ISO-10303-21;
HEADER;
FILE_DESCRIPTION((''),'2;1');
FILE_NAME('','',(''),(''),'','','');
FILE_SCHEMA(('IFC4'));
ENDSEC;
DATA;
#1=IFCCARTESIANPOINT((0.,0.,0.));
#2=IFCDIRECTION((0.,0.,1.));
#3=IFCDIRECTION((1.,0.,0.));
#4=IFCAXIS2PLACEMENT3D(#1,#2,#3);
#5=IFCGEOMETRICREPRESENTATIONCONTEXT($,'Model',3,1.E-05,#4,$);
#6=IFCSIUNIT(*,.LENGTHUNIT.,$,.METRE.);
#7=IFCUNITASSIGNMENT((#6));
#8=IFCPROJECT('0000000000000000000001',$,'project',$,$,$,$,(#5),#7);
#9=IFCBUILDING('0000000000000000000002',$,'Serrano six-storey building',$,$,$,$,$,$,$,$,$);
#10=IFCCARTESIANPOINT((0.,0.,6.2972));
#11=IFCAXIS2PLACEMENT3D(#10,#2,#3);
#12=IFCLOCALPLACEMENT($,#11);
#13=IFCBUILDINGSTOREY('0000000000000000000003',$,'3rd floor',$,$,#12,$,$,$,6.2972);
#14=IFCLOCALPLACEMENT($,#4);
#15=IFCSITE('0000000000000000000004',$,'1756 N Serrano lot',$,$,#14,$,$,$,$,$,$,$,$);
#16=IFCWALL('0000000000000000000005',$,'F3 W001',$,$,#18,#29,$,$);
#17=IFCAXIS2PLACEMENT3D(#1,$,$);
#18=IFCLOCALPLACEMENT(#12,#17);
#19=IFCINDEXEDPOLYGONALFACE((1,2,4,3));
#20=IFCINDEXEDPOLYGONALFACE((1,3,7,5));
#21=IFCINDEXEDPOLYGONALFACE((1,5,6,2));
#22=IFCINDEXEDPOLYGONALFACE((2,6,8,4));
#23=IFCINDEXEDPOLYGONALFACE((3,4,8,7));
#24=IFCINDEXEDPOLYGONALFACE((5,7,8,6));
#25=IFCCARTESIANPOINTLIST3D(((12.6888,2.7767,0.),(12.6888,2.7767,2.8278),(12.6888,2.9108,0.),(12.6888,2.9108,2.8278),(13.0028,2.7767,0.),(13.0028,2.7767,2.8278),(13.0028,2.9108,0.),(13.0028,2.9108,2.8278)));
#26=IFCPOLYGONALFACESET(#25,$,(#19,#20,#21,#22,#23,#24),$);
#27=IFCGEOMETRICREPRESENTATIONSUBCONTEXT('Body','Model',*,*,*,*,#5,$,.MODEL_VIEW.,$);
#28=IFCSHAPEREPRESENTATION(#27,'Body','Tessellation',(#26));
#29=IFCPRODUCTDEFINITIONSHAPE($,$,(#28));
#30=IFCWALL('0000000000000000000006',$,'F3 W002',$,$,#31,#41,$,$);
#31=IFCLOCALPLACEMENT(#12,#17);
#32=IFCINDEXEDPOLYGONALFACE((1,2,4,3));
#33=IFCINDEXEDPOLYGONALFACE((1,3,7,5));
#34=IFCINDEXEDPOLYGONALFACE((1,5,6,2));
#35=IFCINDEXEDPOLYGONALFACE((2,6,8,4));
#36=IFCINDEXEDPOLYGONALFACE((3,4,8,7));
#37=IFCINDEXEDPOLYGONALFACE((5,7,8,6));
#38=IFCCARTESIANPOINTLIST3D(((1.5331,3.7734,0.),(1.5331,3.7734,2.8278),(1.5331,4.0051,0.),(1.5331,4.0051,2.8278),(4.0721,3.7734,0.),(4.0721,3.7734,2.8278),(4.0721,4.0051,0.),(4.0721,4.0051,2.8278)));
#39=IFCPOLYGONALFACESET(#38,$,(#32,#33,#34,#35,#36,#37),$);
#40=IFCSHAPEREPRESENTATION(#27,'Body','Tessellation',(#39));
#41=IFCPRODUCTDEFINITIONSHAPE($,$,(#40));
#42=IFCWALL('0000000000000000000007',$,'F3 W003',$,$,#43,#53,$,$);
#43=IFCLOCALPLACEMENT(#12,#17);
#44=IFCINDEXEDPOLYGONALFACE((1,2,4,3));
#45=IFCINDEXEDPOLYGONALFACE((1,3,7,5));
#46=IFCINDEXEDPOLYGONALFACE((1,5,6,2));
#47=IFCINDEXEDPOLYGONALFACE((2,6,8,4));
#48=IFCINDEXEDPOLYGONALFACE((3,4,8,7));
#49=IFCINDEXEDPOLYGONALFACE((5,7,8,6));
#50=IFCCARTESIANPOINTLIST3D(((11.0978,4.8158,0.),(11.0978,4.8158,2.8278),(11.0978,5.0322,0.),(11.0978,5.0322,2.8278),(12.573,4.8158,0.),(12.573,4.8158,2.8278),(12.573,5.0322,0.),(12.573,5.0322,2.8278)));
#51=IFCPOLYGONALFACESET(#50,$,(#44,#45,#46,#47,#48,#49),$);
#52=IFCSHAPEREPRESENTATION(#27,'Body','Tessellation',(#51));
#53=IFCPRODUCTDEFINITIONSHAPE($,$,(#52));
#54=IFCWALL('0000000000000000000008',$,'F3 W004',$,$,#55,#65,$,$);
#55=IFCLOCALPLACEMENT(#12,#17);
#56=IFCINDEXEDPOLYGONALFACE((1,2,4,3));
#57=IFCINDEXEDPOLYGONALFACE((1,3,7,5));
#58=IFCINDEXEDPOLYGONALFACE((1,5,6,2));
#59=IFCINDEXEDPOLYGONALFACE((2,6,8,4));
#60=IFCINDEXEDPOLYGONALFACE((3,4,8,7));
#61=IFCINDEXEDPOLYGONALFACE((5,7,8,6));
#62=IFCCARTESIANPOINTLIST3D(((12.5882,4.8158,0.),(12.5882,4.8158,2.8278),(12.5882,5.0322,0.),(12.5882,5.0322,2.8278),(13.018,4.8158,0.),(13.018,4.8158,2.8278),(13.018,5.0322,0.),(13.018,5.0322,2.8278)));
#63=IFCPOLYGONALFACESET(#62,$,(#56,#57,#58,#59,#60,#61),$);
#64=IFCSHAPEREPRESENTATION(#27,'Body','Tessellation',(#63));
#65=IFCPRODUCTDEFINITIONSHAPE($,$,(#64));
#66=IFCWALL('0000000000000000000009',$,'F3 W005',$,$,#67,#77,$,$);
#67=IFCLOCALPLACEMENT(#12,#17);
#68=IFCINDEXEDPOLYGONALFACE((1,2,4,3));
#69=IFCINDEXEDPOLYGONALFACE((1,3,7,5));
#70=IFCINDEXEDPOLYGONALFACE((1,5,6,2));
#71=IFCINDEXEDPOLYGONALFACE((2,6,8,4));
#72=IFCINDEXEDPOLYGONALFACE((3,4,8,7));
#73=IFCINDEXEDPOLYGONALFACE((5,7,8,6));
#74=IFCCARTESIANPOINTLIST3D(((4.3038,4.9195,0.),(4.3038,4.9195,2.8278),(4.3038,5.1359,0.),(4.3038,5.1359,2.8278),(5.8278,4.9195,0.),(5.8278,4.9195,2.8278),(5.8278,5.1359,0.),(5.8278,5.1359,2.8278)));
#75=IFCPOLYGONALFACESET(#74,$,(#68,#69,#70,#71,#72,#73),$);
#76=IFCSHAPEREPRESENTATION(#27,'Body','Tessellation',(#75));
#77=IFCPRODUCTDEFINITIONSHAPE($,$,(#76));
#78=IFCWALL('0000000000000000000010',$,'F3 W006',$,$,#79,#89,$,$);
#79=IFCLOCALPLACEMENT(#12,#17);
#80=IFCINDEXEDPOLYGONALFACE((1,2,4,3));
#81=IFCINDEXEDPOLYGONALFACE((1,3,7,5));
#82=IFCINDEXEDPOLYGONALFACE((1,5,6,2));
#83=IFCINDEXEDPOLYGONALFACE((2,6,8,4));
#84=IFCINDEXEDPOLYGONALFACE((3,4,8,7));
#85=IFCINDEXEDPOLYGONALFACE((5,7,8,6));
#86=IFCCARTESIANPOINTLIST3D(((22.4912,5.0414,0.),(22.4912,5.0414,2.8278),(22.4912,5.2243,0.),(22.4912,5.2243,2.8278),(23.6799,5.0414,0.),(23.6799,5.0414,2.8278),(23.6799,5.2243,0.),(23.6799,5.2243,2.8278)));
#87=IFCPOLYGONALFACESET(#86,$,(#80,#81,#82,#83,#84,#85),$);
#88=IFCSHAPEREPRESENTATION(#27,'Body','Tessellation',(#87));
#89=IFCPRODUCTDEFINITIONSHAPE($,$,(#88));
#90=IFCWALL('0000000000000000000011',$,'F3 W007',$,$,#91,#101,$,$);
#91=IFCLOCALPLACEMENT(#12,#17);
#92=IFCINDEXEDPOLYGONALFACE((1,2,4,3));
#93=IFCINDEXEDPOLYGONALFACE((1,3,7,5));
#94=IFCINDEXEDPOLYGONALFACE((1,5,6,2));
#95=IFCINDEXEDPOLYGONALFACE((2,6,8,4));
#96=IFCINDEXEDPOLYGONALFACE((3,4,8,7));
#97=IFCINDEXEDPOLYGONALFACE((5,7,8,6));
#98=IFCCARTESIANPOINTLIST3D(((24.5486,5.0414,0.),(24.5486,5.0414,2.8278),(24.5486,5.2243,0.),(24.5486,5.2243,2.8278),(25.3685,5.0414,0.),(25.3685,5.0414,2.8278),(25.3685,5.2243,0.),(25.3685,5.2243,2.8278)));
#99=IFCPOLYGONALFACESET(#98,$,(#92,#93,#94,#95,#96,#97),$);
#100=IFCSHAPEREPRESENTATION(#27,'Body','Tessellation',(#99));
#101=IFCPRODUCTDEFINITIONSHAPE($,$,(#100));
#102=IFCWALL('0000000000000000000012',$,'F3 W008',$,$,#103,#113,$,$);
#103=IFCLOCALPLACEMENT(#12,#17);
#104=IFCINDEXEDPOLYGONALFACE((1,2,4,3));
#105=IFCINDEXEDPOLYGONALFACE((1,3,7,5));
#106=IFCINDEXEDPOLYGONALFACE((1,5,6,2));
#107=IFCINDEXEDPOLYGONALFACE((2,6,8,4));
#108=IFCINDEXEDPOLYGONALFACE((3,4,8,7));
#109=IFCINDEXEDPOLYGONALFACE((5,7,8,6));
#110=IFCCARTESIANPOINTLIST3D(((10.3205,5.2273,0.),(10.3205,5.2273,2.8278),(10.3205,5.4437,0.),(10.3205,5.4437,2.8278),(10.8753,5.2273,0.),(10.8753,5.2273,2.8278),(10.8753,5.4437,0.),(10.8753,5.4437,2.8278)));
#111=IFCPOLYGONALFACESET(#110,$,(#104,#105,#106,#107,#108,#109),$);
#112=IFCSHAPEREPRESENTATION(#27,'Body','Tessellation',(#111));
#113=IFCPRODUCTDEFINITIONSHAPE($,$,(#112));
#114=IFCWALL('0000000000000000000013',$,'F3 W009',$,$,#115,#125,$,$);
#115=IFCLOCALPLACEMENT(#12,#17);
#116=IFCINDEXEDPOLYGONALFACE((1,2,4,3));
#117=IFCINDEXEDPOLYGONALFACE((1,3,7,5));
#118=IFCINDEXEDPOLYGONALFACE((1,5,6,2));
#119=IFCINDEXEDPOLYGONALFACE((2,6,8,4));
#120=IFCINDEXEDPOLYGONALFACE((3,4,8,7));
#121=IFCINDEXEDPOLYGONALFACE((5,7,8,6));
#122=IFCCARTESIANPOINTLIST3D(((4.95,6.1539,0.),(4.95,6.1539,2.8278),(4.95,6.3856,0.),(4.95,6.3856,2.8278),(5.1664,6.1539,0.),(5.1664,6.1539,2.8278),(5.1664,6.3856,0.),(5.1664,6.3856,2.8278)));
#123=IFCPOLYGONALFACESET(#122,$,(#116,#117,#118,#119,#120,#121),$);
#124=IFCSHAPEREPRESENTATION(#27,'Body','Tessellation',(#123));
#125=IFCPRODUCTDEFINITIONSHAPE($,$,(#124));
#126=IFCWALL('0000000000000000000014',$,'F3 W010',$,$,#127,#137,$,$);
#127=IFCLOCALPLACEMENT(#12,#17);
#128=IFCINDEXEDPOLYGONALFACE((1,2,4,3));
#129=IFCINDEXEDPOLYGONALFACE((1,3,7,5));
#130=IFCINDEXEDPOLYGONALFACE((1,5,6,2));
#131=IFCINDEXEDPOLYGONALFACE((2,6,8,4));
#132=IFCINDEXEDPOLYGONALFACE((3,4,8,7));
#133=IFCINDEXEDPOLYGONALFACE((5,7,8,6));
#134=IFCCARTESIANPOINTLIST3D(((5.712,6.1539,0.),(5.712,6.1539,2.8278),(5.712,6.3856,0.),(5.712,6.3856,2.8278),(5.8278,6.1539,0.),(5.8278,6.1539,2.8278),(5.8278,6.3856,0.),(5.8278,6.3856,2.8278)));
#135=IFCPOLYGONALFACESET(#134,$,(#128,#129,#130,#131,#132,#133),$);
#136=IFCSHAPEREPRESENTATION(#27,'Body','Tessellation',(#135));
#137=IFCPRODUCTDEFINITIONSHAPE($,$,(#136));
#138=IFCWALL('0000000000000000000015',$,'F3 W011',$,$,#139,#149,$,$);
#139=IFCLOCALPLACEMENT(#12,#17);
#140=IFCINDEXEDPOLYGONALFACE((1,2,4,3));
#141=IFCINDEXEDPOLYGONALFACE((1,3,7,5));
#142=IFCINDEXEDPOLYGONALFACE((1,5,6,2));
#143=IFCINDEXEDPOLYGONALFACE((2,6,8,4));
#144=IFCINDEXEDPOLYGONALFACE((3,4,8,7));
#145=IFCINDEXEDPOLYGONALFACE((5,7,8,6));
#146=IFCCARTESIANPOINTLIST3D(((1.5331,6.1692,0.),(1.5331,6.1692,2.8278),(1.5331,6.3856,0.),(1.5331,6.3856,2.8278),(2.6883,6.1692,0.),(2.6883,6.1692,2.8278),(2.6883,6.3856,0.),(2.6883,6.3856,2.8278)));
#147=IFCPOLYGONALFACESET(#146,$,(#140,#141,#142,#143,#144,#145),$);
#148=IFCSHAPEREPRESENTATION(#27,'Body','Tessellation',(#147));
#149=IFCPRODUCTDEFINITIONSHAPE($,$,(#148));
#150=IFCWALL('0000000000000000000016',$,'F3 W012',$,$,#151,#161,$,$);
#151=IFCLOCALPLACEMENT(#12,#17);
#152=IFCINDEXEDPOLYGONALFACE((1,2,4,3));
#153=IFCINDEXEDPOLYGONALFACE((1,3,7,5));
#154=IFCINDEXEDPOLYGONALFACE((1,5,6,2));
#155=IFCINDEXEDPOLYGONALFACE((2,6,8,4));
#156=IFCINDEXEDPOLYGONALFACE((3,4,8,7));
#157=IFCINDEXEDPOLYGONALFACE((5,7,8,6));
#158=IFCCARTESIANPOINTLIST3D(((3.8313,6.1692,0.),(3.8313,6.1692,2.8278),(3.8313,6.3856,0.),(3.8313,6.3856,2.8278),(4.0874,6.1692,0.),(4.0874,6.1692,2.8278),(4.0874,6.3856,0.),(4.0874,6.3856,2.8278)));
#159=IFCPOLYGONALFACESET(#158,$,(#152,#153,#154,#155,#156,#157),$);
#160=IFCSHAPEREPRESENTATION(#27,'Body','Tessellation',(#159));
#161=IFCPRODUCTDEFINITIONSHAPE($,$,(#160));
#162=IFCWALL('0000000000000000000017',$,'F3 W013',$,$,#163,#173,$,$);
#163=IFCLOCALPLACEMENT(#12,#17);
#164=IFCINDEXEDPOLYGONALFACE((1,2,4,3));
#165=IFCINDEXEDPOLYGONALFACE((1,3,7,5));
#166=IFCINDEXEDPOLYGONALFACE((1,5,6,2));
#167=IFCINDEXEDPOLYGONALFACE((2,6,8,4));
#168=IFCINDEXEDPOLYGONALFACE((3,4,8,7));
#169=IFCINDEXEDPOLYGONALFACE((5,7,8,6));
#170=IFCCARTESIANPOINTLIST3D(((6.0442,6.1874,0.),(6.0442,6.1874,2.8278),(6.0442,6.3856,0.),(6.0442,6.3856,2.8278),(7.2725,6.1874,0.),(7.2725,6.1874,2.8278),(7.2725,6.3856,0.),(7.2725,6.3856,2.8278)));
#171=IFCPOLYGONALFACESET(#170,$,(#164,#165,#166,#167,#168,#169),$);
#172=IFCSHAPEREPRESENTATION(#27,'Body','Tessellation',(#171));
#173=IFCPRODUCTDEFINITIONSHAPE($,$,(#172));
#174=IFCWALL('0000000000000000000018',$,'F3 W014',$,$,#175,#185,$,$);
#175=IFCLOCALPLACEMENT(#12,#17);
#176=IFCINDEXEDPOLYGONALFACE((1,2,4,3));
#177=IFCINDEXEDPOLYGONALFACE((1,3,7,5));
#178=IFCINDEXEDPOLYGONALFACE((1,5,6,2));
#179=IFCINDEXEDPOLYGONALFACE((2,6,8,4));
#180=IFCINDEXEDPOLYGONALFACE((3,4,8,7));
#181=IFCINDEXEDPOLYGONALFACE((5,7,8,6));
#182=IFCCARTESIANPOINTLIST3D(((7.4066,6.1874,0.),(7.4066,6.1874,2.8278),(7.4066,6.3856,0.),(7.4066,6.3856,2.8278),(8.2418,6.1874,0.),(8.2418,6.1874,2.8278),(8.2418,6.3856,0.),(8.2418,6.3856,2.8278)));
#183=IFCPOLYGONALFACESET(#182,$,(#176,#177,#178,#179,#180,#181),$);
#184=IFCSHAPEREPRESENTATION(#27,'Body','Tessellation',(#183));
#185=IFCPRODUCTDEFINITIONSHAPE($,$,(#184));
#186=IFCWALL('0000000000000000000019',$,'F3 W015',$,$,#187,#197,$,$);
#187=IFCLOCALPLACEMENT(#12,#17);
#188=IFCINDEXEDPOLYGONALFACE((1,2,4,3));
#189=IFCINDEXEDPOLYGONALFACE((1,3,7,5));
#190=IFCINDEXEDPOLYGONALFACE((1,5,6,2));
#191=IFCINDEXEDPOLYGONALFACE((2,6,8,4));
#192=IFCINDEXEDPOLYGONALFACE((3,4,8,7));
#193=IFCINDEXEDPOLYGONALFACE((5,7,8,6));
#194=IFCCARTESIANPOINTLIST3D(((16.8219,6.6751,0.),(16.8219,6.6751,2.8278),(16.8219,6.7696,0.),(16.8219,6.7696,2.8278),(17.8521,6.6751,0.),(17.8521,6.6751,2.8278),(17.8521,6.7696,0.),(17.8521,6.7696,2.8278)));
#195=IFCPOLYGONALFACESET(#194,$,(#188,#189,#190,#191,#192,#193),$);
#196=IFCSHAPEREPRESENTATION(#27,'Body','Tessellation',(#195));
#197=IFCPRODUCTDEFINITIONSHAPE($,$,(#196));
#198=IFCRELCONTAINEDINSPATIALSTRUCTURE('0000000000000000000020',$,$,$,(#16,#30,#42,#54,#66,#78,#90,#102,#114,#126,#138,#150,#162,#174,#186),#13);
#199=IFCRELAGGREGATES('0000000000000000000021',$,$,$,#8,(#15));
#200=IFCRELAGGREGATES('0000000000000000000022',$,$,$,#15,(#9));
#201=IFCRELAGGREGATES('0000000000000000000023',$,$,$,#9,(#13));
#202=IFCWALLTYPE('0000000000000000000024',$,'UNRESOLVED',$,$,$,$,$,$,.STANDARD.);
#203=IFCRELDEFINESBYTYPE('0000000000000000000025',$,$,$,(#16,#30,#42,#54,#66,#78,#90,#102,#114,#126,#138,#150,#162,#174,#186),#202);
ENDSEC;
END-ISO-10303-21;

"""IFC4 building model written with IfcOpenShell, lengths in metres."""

from ifc_helpers import new_model, si_unit, frame, origin_with_axes, place, context, subcontext, project, spatial, polyline, outline, extrude, type_object, element, save


model = new_model("IFC4")

# Units and contexts
model_context = context("Model", 3, precision=1e-05, world=origin_with_axes())
body_context = subcontext(model_context, "Body", "Model", "MODEL_VIEW")
ifc_project = project(units=[si_unit("LENGTHUNIT", "METRE")], contexts=[model_context])

# Site, building, storey
site_placement = place(None, origin_with_axes())
site = spatial("IfcSite", under=ifc_project, at=site_placement, Name="1756 N Serrano lot")
building = spatial("IfcBuilding", under=site, Name="Serrano six-storey building")
storey_placement = place(None, frame((0.0, 0.0, 6.2972), z_axis=(0.0, 0.0, 1.0), x_axis=(1.0, 0.0, 0.0)))
storey = spatial("IfcBuildingStorey", under=building, at=storey_placement, Name="3rd floor", Elevation=6.2972)

# Walls
wall_type = type_object("IfcWallType", Name="UNRESOLVED", PredefinedType="STANDARD")
wall_1_placement = place(storey_placement, frame((0.0, 0.0, -6.2972), z_axis=(0.0, 0.0, 1.0), x_axis=(1.0, 0.0, 0.0)))
element("IfcWall", 1, at=wall_1_placement, inside=storey, type_object=wall_type, Name="F3 W001", context=body_context, shape_type="SweptSolid", body=[
    extrude(outline(polyline([(13.0028, 2.9108), (13.0028, 2.7767), (12.6888, 2.7767), (12.6888, 2.9108), (13.0028, 2.9108)])), frame((0.0, 0.0, 6.2972)), (0.0, 0.0, 1.0), 2.8278),
])
wall_2_placement = place(storey_placement, frame((0.0, 0.0, -6.2972), z_axis=(0.0, 0.0, 1.0), x_axis=(1.0, 0.0, 0.0)))
element("IfcWall", 2, at=wall_2_placement, inside=storey, type_object=wall_type, Name="F3 W002", context=body_context, shape_type="SweptSolid", body=[
    extrude(outline(polyline([(4.0721, 4.0051), (4.0721, 3.7734), (1.5331, 3.7734), (1.5331, 4.0051), (4.0721, 4.0051)])), frame((0.0, 0.0, 6.2972)), (0.0, 0.0, 1.0), 2.8278),
])
wall_3_placement = place(storey_placement, frame((0.0, 0.0, -6.2972), z_axis=(0.0, 0.0, 1.0), x_axis=(1.0, 0.0, 0.0)))
element("IfcWall", 3, at=wall_3_placement, inside=storey, type_object=wall_type, Name="F3 W003", context=body_context, shape_type="SweptSolid", body=[
    extrude(outline(polyline([(12.573, 5.0322), (12.573, 4.8158), (11.0978, 4.8158), (11.0978, 5.0322), (12.573, 5.0322)])), frame((0.0, 0.0, 6.2972)), (0.0, 0.0, 1.0), 2.8278),
])
wall_4_placement = place(storey_placement, frame((0.0, 0.0, -6.2972), z_axis=(0.0, 0.0, 1.0), x_axis=(1.0, 0.0, 0.0)))
element("IfcWall", 4, at=wall_4_placement, inside=storey, type_object=wall_type, Name="F3 W004", context=body_context, shape_type="SweptSolid", body=[
    extrude(outline(polyline([(13.018, 5.0322), (13.018, 4.8158), (12.5882, 4.8158), (12.5882, 5.0322), (13.018, 5.0322)])), frame((0.0, 0.0, 6.2972)), (0.0, 0.0, 1.0), 2.8278),
])
wall_5_placement = place(storey_placement, frame((0.0, 0.0, -6.2972), z_axis=(0.0, 0.0, 1.0), x_axis=(1.0, 0.0, 0.0)))
element("IfcWall", 5, at=wall_5_placement, inside=storey, type_object=wall_type, Name="F3 W005", context=body_context, shape_type="SweptSolid", body=[
    extrude(outline(polyline([(5.8278, 5.1359), (5.8278, 4.9195), (4.3038, 4.9195), (4.3038, 5.1359), (5.8278, 5.1359)])), frame((0.0, 0.0, 6.2972)), (0.0, 0.0, 1.0), 2.8278),
])
wall_6_placement = place(storey_placement, frame((0.0, 0.0, -6.2972), z_axis=(0.0, 0.0, 1.0), x_axis=(1.0, 0.0, 0.0)))
element("IfcWall", 6, at=wall_6_placement, inside=storey, type_object=wall_type, Name="F3 W006", context=body_context, shape_type="SweptSolid", body=[
    extrude(outline(polyline([(23.6799, 5.2243), (23.6799, 5.0414), (22.4912, 5.0414), (22.4912, 5.2243), (23.6799, 5.2243)])), frame((0.0, 0.0, 6.2972)), (0.0, 0.0, 1.0), 2.8278),
])
wall_7_placement = place(storey_placement, frame((0.0, 0.0, -6.2972), z_axis=(0.0, 0.0, 1.0), x_axis=(1.0, 0.0, 0.0)))
element("IfcWall", 7, at=wall_7_placement, inside=storey, type_object=wall_type, Name="F3 W007", context=body_context, shape_type="SweptSolid", body=[
    extrude(outline(polyline([(25.3685, 5.2243), (25.3685, 5.0414), (24.5486, 5.0414), (24.5486, 5.2243), (25.3685, 5.2243)])), frame((0.0, 0.0, 6.2972)), (0.0, 0.0, 1.0), 2.8278),
])
wall_8_placement = place(storey_placement, frame((0.0, 0.0, -6.2972), z_axis=(0.0, 0.0, 1.0), x_axis=(1.0, 0.0, 0.0)))
element("IfcWall", 8, at=wall_8_placement, inside=storey, type_object=wall_type, Name="F3 W008", context=body_context, shape_type="SweptSolid", body=[
    extrude(outline(polyline([(10.8753, 5.4437), (10.8753, 5.2273), (10.3205, 5.2273), (10.3205, 5.4437), (10.8753, 5.4437)])), frame((0.0, 0.0, 6.2972)), (0.0, 0.0, 1.0), 2.8278),
])
wall_9_placement = place(storey_placement, frame((0.0, 0.0, -6.2972), z_axis=(0.0, 0.0, 1.0), x_axis=(1.0, 0.0, 0.0)))
element("IfcWall", 9, at=wall_9_placement, inside=storey, type_object=wall_type, Name="F3 W009", context=body_context, shape_type="SweptSolid", body=[
    extrude(outline(polyline([(5.1664, 6.3856), (5.1664, 6.1539), (4.95, 6.1539), (4.95, 6.3856), (5.1664, 6.3856)])), frame((0.0, 0.0, 6.2972)), (0.0, 0.0, 1.0), 2.8278),
])
wall_10_placement = place(storey_placement, frame((0.0, 0.0, -6.2972), z_axis=(0.0, 0.0, 1.0), x_axis=(1.0, 0.0, 0.0)))
element("IfcWall", 10, at=wall_10_placement, inside=storey, type_object=wall_type, Name="F3 W010", context=body_context, shape_type="SweptSolid", body=[
    extrude(outline(polyline([(5.8278, 6.3856), (5.8278, 6.1539), (5.712, 6.1539), (5.712, 6.3856), (5.8278, 6.3856)])), frame((0.0, 0.0, 6.2972)), (0.0, 0.0, 1.0), 2.8278),
])
wall_11_placement = place(storey_placement, frame((0.0, 0.0, -6.2972), z_axis=(0.0, 0.0, 1.0), x_axis=(1.0, 0.0, 0.0)))
element("IfcWall", 11, at=wall_11_placement, inside=storey, type_object=wall_type, Name="F3 W011", context=body_context, shape_type="SweptSolid", body=[
    extrude(outline(polyline([(2.6883, 6.3856), (2.6883, 6.1692), (1.5331, 6.1692), (1.5331, 6.3856), (2.6883, 6.3856)])), frame((0.0, 0.0, 6.2972)), (0.0, 0.0, 1.0), 2.8278),
])
wall_12_placement = place(storey_placement, frame((0.0, 0.0, -6.2972), z_axis=(0.0, 0.0, 1.0), x_axis=(1.0, 0.0, 0.0)))
element("IfcWall", 12, at=wall_12_placement, inside=storey, type_object=wall_type, Name="F3 W012", context=body_context, shape_type="SweptSolid", body=[
    extrude(outline(polyline([(4.0874, 6.3856), (4.0874, 6.1692), (3.8313, 6.1692), (3.8313, 6.3856), (4.0874, 6.3856)])), frame((0.0, 0.0, 6.2972)), (0.0, 0.0, 1.0), 2.8278),
])
wall_13_placement = place(storey_placement, frame((0.0, 0.0, -6.2972), z_axis=(0.0, 0.0, 1.0), x_axis=(1.0, 0.0, 0.0)))
element("IfcWall", 13, at=wall_13_placement, inside=storey, type_object=wall_type, Name="F3 W013", context=body_context, shape_type="SweptSolid", body=[
    extrude(outline(polyline([(7.2725, 6.3856), (7.2725, 6.1874), (6.0442, 6.1874), (6.0442, 6.3856), (7.2725, 6.3856)])), frame((0.0, 0.0, 6.2972)), (0.0, 0.0, 1.0), 2.8278),
])
wall_14_placement = place(storey_placement, frame((0.0, 0.0, -6.2972), z_axis=(0.0, 0.0, 1.0), x_axis=(1.0, 0.0, 0.0)))
element("IfcWall", 14, at=wall_14_placement, inside=storey, type_object=wall_type, Name="F3 W014", context=body_context, shape_type="SweptSolid", body=[
    extrude(outline(polyline([(8.2418, 6.3856), (8.2418, 6.1874), (7.4066, 6.1874), (7.4066, 6.3856), (8.2418, 6.3856)])), frame((0.0, 0.0, 6.2972)), (0.0, 0.0, 1.0), 2.8278),
])
wall_15_placement = place(storey_placement, frame((0.0, 0.0, -6.2972), z_axis=(0.0, 0.0, 1.0), x_axis=(1.0, 0.0, 0.0)))
element("IfcWall", 15, at=wall_15_placement, inside=storey, type_object=wall_type, Name="F3 W015", context=body_context, shape_type="SweptSolid", body=[
    extrude(outline(polyline([(17.8521, 6.7696), (17.8521, 6.6751), (16.8219, 6.6751), (16.8219, 6.7696), (17.8521, 6.7696)])), frame((0.0, 0.0, 6.2972)), (0.0, 0.0, 1.0), 2.8278),
])

save(model, "model.ifc")
